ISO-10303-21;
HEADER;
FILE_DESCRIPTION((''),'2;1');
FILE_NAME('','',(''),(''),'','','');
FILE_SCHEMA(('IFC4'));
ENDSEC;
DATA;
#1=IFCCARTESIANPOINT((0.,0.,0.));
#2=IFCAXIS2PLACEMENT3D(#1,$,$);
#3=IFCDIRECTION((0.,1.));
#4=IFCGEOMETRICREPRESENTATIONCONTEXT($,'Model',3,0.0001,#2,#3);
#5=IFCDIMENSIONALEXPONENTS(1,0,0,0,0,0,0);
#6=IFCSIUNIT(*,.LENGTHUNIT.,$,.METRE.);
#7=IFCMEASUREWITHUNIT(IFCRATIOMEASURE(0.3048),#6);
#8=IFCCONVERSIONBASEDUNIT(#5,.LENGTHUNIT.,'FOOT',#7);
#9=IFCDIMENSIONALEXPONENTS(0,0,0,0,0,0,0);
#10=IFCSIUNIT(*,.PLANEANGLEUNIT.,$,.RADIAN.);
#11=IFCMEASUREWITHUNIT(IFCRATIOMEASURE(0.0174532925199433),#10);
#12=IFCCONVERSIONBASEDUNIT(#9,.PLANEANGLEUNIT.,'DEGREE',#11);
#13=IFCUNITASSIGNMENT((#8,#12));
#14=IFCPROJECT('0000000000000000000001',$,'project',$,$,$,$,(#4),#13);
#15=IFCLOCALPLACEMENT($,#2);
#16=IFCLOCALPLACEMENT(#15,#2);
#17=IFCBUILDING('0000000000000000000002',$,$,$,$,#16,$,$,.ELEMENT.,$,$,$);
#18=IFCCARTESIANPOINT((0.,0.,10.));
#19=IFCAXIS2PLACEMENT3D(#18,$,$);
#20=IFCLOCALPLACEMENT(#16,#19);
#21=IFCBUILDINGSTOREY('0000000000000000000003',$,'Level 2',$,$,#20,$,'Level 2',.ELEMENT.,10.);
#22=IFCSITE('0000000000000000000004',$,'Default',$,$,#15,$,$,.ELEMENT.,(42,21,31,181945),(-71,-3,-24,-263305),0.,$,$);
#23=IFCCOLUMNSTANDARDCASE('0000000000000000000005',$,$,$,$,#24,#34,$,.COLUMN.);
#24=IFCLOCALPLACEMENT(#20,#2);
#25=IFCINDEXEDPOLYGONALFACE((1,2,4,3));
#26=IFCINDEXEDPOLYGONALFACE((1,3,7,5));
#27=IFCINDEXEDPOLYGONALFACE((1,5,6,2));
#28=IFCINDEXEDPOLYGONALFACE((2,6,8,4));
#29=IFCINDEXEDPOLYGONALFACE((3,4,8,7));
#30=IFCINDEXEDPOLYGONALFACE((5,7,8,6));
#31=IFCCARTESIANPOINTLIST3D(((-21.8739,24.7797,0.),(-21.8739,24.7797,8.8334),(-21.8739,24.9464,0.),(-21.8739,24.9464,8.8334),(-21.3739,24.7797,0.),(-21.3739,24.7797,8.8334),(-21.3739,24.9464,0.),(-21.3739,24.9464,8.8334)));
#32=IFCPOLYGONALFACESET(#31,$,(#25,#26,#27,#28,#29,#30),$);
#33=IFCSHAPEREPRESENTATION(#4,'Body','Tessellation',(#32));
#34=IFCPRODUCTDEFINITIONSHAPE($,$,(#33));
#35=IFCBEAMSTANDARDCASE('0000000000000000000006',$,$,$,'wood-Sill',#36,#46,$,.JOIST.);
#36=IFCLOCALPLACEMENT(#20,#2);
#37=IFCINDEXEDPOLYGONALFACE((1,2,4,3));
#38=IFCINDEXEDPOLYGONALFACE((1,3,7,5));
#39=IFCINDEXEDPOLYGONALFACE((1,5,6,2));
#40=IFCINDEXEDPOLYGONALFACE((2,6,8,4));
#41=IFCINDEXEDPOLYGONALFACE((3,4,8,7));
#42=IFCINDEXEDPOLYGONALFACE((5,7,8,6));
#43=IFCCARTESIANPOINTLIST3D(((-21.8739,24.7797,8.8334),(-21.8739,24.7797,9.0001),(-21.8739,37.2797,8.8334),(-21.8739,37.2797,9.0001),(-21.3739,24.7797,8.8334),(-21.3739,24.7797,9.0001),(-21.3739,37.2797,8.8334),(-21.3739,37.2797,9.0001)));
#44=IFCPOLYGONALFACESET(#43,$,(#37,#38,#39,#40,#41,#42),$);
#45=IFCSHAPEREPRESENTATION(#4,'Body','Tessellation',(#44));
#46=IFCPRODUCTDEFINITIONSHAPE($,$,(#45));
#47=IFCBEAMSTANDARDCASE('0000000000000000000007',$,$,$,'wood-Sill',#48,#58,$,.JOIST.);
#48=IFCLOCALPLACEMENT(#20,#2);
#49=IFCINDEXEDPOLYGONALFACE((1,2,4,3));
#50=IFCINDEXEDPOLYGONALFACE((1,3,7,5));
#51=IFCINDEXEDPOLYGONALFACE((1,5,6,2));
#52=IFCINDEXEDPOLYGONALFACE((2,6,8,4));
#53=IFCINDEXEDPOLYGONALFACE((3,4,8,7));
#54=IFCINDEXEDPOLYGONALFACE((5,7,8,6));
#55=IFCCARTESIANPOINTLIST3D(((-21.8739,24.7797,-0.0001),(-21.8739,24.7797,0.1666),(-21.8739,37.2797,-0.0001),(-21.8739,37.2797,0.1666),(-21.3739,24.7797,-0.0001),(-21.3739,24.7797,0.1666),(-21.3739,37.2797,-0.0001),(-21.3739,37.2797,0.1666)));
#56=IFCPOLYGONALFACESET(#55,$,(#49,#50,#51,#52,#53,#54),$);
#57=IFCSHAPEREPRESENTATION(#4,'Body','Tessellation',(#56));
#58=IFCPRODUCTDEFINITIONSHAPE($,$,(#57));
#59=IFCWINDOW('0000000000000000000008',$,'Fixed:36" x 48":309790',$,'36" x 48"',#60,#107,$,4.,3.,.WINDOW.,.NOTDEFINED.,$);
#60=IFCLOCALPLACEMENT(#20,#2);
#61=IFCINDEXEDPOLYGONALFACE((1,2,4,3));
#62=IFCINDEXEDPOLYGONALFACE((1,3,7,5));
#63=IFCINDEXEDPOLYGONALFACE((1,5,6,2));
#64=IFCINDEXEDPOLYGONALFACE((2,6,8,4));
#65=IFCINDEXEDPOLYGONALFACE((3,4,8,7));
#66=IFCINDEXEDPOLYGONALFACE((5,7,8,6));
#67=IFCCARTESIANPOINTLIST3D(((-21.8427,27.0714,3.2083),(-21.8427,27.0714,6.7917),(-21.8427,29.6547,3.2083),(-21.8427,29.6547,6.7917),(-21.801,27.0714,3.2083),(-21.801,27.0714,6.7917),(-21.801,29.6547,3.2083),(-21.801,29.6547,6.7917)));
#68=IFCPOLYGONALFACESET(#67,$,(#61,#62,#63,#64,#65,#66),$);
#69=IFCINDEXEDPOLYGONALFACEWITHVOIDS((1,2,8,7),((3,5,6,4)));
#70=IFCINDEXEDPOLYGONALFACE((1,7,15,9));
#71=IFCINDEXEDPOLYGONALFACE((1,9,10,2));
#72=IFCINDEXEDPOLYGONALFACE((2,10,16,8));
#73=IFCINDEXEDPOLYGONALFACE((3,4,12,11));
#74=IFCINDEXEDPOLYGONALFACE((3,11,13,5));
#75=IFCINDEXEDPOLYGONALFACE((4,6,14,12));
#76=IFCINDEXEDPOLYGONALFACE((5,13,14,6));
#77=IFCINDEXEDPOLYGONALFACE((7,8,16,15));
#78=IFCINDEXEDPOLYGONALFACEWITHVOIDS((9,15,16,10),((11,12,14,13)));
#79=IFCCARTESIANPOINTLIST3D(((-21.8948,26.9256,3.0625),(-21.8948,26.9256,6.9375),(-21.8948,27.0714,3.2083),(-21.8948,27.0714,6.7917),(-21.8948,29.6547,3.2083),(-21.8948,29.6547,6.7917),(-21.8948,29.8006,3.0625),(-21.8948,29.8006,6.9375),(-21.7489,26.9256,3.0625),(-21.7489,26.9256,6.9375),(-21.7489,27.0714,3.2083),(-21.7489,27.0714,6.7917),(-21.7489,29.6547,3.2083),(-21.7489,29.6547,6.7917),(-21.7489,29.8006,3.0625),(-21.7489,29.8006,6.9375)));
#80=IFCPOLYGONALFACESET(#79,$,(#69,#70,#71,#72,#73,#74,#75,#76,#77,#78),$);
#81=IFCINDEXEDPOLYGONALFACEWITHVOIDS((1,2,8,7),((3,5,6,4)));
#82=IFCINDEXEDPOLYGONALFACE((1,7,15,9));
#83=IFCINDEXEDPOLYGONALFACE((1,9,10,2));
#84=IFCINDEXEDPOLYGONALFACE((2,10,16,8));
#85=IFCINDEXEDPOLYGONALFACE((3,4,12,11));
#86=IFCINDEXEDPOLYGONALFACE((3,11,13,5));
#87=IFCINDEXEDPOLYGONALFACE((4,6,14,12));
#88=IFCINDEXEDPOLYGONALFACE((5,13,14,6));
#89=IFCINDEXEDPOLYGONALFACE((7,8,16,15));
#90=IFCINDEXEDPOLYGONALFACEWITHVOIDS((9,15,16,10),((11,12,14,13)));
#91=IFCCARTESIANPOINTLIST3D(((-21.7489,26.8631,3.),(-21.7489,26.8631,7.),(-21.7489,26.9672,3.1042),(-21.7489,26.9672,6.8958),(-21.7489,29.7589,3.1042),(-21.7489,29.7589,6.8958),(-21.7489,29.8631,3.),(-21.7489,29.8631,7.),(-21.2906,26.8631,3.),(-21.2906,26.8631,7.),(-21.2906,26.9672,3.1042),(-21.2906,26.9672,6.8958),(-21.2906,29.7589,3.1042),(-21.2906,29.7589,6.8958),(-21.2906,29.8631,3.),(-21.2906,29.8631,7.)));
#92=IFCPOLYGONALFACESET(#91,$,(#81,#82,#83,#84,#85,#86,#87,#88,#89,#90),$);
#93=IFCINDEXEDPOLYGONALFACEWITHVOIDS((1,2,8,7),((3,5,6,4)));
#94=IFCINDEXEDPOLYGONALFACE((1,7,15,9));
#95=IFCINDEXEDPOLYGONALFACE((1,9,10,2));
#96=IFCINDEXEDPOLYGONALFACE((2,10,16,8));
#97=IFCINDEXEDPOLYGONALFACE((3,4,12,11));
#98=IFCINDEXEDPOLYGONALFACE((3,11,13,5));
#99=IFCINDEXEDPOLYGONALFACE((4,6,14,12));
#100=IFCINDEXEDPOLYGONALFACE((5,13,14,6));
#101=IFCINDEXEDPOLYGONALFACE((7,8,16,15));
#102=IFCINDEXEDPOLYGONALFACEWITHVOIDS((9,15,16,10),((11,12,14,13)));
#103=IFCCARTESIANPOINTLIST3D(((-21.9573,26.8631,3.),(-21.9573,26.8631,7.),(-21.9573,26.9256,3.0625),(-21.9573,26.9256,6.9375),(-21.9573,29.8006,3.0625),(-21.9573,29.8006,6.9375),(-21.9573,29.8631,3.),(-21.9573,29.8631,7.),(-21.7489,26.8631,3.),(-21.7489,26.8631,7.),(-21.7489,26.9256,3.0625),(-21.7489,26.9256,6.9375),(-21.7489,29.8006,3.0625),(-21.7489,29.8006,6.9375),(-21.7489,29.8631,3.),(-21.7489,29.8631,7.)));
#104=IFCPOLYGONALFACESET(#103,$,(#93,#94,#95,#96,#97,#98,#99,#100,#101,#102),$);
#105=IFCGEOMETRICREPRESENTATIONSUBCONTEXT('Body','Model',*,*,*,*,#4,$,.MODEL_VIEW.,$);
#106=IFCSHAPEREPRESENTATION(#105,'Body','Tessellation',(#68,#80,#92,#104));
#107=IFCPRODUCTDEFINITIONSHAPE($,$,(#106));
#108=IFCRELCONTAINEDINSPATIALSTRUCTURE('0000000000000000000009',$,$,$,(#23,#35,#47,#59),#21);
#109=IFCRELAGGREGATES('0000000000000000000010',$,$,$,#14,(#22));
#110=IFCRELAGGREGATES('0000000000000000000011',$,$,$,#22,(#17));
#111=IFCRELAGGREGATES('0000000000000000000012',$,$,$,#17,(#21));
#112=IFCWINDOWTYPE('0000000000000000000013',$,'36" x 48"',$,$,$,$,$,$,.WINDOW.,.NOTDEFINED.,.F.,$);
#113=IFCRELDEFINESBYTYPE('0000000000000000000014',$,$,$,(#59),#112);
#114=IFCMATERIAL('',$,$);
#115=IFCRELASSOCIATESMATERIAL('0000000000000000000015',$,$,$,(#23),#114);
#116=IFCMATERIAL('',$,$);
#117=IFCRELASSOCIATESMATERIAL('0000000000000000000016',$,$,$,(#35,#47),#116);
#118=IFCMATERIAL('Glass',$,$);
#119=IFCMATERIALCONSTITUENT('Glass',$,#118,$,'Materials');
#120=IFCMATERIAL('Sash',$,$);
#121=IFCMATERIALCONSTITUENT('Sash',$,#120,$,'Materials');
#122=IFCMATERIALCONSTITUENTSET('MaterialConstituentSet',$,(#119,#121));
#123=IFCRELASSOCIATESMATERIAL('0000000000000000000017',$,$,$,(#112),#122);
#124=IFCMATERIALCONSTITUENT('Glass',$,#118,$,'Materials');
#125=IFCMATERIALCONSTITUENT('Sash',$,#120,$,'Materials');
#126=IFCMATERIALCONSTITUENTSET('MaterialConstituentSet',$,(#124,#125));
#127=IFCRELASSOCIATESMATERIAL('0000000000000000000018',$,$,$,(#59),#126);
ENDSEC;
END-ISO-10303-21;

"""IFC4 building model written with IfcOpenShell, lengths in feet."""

from ifc_helpers import new_model, entity, si_unit, converted_unit, direction, frame, frame_2d, origin, origin_with_axes, place, context, subcontext, project, spatial, polyline, rectangle, outline, extrude, source, transform, mapped, material, constituent, constituent_set, type_object, type_shapes, element, save


model = new_model("IFC4")

# Units and contexts
model_context = context("Model", 3, precision=0.0001, world=origin(), true_north=direction((0.0, 1.0)))
body_context = subcontext(model_context, "Body", "Model", "MODEL_VIEW")
ifc_project = project(units=[converted_unit("LENGTHUNIT", "FOOT", entity("IfcRatioMeasure", 0.3048), si_unit("LENGTHUNIT", "METRE"), dimensions=[1, 0, 0, 0, 0, 0, 0]), converted_unit("PLANEANGLEUNIT", "DEGREE", entity("IfcRatioMeasure", 0.0174532925199433), si_unit("PLANEANGLEUNIT", "RADIAN"), dimensions=[0, 0, 0, 0, 0, 0, 0])], contexts=[model_context])

# Site, building, storey
site_placement = place(None, origin())
site = spatial("IfcSite", under=ifc_project, at=site_placement, Name="Default", CompositionType="ELEMENT", RefLatitude=(42, 21, 31, 181945), RefLongitude=(-71, -3, -24, -263305), RefElevation=0.0)
building_placement = place(site_placement, origin())
building = spatial("IfcBuilding", under=site, at=building_placement, CompositionType="ELEMENT")
storey_placement = place(building_placement, frame((0.0, 0.0, 10.0)))
storey = spatial("IfcBuildingStorey", under=building, at=storey_placement, Name="Level 2", LongName="Level 2", CompositionType="ELEMENT", Elevation=10.0)

# Column
ifc_material_1 = material(Name="")
placement_1 = place(storey_placement, frame((-21.6239, 24.7797, 0.0), z_axis=(0.0, 0.0, 1.0), x_axis=(0.0, 1.0, 0.0)))
for number, where, z_axis, x_axis in (
    (1, (0.0833, 0.0, 0.0), (0.0, 0.0, 1.0), (1.0, 0.0, 0.0)),
):
    element("IfcColumnStandardCase", number, at=place(placement_1, frame(where, z_axis=z_axis, x_axis=x_axis)), inside=storey, material=ifc_material_1, PredefinedType="COLUMN", context=model_context, shape_type="SweptSolid", body=[
        extrude(rectangle(XDim=0.1667, YDim=0.5), origin(), (0.0, 0.0, 1.0), 8.8334),
    ])

# Beams
ifc_material_2 = material(Name="")
for number, where, z_axis, x_axis in (
    (2, (0.0, 0.0, 8.9167), (1.0, 0.0, 0.0), (0.0, 0.0, 1.0)),
    (3, (0.0, 0.0, 0.0833), (1.0, 0.0, 0.0), (0.0, 0.0, 1.0)),
):
    element("IfcBeamStandardCase", number, at=place(placement_1, frame(where, z_axis=z_axis, x_axis=x_axis)), inside=storey, material=ifc_material_2, ObjectType="wood-Sill", PredefinedType="JOIST", context=model_context, shape_type="SweptSolid", body=[
        extrude(rectangle(XDim=0.1667, YDim=0.5), origin_with_axes(), (0.0, 0.0, 1.0), 12.5),
    ])

# Window
ifc_material_3 = material(Name="Glass")
ifc_constituent_1 = constituent(ifc_material_3, Name="Glass", Category="Materials")
ifc_material_4 = material(Name="Sash")
ifc_constituent_2 = constituent(ifc_material_4, Name="Sash", Category="Materials")
ifc_constituent_set_1 = constituent_set(constituents=[ifc_constituent_1, ifc_constituent_2], Name="MaterialConstituentSet")
ifc_constituent_3 = constituent(ifc_material_3, Name="Glass", Category="Materials")
ifc_constituent_4 = constituent(ifc_material_4, Name="Sash", Category="Materials")
ifc_constituent_set_2 = constituent_set(constituents=[ifc_constituent_3, ifc_constituent_4], Name="MaterialConstituentSet")
window_type = type_object("IfcWindowType", Name="36\" x 48\"", ParameterTakesPrecedence=False, PartitioningType="NOTDEFINED", PredefinedType="WINDOW", material=ifc_constituent_set_2)
shared_shape = source(origin(), body_context, "Body", "SweptSolid", [
    extrude(rectangle(XDim=2.5833, YDim=0.0417, at=frame_2d((0.0, 0.0), x_axis=(1.0, 0.0))), frame((1.75, 0.5312, 0.2083)), (0.0, 0.0, 1.0), 3.5833),
    extrude(outline(polyline([(-1.4375, -1.9375), (1.4375, -1.9375), (1.4375, 1.9375), (-1.4375, 1.9375), (-1.4375, -1.9375)]), holes=[polyline([(-1.2917, -1.7917), (-1.2917, 1.7917), (1.2917, 1.7917), (1.2917, -1.7917), (-1.2917, -1.7917)])]), frame((1.75, 0.6042, 2.0), z_axis=(0.0, -1.0, 0.0), x_axis=(-1.0, 0.0, 0.0)), (0.0, 0.0, 1.0), 0.1458),
    extrude(outline(polyline([(-1.5, -2.0), (1.5, -2.0), (1.5, 2.0), (-1.5, 2.0), (-1.5, -2.0)]), holes=[polyline([(-1.3958, -1.8958), (-1.3958, 1.8958), (1.3958, 1.8958), (1.3958, -1.8958), (-1.3958, -1.8958)])]), frame((1.75, 0.4583, 2.0), z_axis=(0.0, -1.0, 0.0), x_axis=(-1.0, 0.0, 0.0)), (0.0, 0.0, 1.0), 0.4583),
    extrude(outline(polyline([(-2.0, -1.5), (2.0, -1.5), (2.0, 1.5), (-2.0, 1.5), (-2.0, -1.5)]), holes=[polyline([(-1.9375, -1.4375), (-1.9375, 1.4375), (1.9375, 1.4375), (1.9375, -1.4375), (-1.9375, -1.4375)])]), frame((1.75, 0.6667, 2.0), z_axis=(0.0, -1.0, 0.0), x_axis=(0.0, 0.0, -1.0)), (0.0, 0.0, 1.0), 0.2083),
])
type_shapes(window_type, [shared_shape])
placement_2 = place(placement_1, frame((2.0833, -0.3333, 3.0)))
window_placement = place(placement_2, frame((-0.25, 0.0, 0.0)))
element("IfcWindow", 4, at=window_placement, inside=storey, type_object=window_type, material=ifc_constituent_set_1, Name="Fixed:36\" x 48\":309790", ObjectType="36\" x 48\"", OverallHeight=4.0, OverallWidth=3.0, PartitioningType="NOTDEFINED", PredefinedType="WINDOW", context=body_context, shape_type="MappedRepresentation", body=[
    mapped(shared_shape, transform((0.0, 0.0, 0.0), scale=1.0)),
])

save(model, "model.ifc")
